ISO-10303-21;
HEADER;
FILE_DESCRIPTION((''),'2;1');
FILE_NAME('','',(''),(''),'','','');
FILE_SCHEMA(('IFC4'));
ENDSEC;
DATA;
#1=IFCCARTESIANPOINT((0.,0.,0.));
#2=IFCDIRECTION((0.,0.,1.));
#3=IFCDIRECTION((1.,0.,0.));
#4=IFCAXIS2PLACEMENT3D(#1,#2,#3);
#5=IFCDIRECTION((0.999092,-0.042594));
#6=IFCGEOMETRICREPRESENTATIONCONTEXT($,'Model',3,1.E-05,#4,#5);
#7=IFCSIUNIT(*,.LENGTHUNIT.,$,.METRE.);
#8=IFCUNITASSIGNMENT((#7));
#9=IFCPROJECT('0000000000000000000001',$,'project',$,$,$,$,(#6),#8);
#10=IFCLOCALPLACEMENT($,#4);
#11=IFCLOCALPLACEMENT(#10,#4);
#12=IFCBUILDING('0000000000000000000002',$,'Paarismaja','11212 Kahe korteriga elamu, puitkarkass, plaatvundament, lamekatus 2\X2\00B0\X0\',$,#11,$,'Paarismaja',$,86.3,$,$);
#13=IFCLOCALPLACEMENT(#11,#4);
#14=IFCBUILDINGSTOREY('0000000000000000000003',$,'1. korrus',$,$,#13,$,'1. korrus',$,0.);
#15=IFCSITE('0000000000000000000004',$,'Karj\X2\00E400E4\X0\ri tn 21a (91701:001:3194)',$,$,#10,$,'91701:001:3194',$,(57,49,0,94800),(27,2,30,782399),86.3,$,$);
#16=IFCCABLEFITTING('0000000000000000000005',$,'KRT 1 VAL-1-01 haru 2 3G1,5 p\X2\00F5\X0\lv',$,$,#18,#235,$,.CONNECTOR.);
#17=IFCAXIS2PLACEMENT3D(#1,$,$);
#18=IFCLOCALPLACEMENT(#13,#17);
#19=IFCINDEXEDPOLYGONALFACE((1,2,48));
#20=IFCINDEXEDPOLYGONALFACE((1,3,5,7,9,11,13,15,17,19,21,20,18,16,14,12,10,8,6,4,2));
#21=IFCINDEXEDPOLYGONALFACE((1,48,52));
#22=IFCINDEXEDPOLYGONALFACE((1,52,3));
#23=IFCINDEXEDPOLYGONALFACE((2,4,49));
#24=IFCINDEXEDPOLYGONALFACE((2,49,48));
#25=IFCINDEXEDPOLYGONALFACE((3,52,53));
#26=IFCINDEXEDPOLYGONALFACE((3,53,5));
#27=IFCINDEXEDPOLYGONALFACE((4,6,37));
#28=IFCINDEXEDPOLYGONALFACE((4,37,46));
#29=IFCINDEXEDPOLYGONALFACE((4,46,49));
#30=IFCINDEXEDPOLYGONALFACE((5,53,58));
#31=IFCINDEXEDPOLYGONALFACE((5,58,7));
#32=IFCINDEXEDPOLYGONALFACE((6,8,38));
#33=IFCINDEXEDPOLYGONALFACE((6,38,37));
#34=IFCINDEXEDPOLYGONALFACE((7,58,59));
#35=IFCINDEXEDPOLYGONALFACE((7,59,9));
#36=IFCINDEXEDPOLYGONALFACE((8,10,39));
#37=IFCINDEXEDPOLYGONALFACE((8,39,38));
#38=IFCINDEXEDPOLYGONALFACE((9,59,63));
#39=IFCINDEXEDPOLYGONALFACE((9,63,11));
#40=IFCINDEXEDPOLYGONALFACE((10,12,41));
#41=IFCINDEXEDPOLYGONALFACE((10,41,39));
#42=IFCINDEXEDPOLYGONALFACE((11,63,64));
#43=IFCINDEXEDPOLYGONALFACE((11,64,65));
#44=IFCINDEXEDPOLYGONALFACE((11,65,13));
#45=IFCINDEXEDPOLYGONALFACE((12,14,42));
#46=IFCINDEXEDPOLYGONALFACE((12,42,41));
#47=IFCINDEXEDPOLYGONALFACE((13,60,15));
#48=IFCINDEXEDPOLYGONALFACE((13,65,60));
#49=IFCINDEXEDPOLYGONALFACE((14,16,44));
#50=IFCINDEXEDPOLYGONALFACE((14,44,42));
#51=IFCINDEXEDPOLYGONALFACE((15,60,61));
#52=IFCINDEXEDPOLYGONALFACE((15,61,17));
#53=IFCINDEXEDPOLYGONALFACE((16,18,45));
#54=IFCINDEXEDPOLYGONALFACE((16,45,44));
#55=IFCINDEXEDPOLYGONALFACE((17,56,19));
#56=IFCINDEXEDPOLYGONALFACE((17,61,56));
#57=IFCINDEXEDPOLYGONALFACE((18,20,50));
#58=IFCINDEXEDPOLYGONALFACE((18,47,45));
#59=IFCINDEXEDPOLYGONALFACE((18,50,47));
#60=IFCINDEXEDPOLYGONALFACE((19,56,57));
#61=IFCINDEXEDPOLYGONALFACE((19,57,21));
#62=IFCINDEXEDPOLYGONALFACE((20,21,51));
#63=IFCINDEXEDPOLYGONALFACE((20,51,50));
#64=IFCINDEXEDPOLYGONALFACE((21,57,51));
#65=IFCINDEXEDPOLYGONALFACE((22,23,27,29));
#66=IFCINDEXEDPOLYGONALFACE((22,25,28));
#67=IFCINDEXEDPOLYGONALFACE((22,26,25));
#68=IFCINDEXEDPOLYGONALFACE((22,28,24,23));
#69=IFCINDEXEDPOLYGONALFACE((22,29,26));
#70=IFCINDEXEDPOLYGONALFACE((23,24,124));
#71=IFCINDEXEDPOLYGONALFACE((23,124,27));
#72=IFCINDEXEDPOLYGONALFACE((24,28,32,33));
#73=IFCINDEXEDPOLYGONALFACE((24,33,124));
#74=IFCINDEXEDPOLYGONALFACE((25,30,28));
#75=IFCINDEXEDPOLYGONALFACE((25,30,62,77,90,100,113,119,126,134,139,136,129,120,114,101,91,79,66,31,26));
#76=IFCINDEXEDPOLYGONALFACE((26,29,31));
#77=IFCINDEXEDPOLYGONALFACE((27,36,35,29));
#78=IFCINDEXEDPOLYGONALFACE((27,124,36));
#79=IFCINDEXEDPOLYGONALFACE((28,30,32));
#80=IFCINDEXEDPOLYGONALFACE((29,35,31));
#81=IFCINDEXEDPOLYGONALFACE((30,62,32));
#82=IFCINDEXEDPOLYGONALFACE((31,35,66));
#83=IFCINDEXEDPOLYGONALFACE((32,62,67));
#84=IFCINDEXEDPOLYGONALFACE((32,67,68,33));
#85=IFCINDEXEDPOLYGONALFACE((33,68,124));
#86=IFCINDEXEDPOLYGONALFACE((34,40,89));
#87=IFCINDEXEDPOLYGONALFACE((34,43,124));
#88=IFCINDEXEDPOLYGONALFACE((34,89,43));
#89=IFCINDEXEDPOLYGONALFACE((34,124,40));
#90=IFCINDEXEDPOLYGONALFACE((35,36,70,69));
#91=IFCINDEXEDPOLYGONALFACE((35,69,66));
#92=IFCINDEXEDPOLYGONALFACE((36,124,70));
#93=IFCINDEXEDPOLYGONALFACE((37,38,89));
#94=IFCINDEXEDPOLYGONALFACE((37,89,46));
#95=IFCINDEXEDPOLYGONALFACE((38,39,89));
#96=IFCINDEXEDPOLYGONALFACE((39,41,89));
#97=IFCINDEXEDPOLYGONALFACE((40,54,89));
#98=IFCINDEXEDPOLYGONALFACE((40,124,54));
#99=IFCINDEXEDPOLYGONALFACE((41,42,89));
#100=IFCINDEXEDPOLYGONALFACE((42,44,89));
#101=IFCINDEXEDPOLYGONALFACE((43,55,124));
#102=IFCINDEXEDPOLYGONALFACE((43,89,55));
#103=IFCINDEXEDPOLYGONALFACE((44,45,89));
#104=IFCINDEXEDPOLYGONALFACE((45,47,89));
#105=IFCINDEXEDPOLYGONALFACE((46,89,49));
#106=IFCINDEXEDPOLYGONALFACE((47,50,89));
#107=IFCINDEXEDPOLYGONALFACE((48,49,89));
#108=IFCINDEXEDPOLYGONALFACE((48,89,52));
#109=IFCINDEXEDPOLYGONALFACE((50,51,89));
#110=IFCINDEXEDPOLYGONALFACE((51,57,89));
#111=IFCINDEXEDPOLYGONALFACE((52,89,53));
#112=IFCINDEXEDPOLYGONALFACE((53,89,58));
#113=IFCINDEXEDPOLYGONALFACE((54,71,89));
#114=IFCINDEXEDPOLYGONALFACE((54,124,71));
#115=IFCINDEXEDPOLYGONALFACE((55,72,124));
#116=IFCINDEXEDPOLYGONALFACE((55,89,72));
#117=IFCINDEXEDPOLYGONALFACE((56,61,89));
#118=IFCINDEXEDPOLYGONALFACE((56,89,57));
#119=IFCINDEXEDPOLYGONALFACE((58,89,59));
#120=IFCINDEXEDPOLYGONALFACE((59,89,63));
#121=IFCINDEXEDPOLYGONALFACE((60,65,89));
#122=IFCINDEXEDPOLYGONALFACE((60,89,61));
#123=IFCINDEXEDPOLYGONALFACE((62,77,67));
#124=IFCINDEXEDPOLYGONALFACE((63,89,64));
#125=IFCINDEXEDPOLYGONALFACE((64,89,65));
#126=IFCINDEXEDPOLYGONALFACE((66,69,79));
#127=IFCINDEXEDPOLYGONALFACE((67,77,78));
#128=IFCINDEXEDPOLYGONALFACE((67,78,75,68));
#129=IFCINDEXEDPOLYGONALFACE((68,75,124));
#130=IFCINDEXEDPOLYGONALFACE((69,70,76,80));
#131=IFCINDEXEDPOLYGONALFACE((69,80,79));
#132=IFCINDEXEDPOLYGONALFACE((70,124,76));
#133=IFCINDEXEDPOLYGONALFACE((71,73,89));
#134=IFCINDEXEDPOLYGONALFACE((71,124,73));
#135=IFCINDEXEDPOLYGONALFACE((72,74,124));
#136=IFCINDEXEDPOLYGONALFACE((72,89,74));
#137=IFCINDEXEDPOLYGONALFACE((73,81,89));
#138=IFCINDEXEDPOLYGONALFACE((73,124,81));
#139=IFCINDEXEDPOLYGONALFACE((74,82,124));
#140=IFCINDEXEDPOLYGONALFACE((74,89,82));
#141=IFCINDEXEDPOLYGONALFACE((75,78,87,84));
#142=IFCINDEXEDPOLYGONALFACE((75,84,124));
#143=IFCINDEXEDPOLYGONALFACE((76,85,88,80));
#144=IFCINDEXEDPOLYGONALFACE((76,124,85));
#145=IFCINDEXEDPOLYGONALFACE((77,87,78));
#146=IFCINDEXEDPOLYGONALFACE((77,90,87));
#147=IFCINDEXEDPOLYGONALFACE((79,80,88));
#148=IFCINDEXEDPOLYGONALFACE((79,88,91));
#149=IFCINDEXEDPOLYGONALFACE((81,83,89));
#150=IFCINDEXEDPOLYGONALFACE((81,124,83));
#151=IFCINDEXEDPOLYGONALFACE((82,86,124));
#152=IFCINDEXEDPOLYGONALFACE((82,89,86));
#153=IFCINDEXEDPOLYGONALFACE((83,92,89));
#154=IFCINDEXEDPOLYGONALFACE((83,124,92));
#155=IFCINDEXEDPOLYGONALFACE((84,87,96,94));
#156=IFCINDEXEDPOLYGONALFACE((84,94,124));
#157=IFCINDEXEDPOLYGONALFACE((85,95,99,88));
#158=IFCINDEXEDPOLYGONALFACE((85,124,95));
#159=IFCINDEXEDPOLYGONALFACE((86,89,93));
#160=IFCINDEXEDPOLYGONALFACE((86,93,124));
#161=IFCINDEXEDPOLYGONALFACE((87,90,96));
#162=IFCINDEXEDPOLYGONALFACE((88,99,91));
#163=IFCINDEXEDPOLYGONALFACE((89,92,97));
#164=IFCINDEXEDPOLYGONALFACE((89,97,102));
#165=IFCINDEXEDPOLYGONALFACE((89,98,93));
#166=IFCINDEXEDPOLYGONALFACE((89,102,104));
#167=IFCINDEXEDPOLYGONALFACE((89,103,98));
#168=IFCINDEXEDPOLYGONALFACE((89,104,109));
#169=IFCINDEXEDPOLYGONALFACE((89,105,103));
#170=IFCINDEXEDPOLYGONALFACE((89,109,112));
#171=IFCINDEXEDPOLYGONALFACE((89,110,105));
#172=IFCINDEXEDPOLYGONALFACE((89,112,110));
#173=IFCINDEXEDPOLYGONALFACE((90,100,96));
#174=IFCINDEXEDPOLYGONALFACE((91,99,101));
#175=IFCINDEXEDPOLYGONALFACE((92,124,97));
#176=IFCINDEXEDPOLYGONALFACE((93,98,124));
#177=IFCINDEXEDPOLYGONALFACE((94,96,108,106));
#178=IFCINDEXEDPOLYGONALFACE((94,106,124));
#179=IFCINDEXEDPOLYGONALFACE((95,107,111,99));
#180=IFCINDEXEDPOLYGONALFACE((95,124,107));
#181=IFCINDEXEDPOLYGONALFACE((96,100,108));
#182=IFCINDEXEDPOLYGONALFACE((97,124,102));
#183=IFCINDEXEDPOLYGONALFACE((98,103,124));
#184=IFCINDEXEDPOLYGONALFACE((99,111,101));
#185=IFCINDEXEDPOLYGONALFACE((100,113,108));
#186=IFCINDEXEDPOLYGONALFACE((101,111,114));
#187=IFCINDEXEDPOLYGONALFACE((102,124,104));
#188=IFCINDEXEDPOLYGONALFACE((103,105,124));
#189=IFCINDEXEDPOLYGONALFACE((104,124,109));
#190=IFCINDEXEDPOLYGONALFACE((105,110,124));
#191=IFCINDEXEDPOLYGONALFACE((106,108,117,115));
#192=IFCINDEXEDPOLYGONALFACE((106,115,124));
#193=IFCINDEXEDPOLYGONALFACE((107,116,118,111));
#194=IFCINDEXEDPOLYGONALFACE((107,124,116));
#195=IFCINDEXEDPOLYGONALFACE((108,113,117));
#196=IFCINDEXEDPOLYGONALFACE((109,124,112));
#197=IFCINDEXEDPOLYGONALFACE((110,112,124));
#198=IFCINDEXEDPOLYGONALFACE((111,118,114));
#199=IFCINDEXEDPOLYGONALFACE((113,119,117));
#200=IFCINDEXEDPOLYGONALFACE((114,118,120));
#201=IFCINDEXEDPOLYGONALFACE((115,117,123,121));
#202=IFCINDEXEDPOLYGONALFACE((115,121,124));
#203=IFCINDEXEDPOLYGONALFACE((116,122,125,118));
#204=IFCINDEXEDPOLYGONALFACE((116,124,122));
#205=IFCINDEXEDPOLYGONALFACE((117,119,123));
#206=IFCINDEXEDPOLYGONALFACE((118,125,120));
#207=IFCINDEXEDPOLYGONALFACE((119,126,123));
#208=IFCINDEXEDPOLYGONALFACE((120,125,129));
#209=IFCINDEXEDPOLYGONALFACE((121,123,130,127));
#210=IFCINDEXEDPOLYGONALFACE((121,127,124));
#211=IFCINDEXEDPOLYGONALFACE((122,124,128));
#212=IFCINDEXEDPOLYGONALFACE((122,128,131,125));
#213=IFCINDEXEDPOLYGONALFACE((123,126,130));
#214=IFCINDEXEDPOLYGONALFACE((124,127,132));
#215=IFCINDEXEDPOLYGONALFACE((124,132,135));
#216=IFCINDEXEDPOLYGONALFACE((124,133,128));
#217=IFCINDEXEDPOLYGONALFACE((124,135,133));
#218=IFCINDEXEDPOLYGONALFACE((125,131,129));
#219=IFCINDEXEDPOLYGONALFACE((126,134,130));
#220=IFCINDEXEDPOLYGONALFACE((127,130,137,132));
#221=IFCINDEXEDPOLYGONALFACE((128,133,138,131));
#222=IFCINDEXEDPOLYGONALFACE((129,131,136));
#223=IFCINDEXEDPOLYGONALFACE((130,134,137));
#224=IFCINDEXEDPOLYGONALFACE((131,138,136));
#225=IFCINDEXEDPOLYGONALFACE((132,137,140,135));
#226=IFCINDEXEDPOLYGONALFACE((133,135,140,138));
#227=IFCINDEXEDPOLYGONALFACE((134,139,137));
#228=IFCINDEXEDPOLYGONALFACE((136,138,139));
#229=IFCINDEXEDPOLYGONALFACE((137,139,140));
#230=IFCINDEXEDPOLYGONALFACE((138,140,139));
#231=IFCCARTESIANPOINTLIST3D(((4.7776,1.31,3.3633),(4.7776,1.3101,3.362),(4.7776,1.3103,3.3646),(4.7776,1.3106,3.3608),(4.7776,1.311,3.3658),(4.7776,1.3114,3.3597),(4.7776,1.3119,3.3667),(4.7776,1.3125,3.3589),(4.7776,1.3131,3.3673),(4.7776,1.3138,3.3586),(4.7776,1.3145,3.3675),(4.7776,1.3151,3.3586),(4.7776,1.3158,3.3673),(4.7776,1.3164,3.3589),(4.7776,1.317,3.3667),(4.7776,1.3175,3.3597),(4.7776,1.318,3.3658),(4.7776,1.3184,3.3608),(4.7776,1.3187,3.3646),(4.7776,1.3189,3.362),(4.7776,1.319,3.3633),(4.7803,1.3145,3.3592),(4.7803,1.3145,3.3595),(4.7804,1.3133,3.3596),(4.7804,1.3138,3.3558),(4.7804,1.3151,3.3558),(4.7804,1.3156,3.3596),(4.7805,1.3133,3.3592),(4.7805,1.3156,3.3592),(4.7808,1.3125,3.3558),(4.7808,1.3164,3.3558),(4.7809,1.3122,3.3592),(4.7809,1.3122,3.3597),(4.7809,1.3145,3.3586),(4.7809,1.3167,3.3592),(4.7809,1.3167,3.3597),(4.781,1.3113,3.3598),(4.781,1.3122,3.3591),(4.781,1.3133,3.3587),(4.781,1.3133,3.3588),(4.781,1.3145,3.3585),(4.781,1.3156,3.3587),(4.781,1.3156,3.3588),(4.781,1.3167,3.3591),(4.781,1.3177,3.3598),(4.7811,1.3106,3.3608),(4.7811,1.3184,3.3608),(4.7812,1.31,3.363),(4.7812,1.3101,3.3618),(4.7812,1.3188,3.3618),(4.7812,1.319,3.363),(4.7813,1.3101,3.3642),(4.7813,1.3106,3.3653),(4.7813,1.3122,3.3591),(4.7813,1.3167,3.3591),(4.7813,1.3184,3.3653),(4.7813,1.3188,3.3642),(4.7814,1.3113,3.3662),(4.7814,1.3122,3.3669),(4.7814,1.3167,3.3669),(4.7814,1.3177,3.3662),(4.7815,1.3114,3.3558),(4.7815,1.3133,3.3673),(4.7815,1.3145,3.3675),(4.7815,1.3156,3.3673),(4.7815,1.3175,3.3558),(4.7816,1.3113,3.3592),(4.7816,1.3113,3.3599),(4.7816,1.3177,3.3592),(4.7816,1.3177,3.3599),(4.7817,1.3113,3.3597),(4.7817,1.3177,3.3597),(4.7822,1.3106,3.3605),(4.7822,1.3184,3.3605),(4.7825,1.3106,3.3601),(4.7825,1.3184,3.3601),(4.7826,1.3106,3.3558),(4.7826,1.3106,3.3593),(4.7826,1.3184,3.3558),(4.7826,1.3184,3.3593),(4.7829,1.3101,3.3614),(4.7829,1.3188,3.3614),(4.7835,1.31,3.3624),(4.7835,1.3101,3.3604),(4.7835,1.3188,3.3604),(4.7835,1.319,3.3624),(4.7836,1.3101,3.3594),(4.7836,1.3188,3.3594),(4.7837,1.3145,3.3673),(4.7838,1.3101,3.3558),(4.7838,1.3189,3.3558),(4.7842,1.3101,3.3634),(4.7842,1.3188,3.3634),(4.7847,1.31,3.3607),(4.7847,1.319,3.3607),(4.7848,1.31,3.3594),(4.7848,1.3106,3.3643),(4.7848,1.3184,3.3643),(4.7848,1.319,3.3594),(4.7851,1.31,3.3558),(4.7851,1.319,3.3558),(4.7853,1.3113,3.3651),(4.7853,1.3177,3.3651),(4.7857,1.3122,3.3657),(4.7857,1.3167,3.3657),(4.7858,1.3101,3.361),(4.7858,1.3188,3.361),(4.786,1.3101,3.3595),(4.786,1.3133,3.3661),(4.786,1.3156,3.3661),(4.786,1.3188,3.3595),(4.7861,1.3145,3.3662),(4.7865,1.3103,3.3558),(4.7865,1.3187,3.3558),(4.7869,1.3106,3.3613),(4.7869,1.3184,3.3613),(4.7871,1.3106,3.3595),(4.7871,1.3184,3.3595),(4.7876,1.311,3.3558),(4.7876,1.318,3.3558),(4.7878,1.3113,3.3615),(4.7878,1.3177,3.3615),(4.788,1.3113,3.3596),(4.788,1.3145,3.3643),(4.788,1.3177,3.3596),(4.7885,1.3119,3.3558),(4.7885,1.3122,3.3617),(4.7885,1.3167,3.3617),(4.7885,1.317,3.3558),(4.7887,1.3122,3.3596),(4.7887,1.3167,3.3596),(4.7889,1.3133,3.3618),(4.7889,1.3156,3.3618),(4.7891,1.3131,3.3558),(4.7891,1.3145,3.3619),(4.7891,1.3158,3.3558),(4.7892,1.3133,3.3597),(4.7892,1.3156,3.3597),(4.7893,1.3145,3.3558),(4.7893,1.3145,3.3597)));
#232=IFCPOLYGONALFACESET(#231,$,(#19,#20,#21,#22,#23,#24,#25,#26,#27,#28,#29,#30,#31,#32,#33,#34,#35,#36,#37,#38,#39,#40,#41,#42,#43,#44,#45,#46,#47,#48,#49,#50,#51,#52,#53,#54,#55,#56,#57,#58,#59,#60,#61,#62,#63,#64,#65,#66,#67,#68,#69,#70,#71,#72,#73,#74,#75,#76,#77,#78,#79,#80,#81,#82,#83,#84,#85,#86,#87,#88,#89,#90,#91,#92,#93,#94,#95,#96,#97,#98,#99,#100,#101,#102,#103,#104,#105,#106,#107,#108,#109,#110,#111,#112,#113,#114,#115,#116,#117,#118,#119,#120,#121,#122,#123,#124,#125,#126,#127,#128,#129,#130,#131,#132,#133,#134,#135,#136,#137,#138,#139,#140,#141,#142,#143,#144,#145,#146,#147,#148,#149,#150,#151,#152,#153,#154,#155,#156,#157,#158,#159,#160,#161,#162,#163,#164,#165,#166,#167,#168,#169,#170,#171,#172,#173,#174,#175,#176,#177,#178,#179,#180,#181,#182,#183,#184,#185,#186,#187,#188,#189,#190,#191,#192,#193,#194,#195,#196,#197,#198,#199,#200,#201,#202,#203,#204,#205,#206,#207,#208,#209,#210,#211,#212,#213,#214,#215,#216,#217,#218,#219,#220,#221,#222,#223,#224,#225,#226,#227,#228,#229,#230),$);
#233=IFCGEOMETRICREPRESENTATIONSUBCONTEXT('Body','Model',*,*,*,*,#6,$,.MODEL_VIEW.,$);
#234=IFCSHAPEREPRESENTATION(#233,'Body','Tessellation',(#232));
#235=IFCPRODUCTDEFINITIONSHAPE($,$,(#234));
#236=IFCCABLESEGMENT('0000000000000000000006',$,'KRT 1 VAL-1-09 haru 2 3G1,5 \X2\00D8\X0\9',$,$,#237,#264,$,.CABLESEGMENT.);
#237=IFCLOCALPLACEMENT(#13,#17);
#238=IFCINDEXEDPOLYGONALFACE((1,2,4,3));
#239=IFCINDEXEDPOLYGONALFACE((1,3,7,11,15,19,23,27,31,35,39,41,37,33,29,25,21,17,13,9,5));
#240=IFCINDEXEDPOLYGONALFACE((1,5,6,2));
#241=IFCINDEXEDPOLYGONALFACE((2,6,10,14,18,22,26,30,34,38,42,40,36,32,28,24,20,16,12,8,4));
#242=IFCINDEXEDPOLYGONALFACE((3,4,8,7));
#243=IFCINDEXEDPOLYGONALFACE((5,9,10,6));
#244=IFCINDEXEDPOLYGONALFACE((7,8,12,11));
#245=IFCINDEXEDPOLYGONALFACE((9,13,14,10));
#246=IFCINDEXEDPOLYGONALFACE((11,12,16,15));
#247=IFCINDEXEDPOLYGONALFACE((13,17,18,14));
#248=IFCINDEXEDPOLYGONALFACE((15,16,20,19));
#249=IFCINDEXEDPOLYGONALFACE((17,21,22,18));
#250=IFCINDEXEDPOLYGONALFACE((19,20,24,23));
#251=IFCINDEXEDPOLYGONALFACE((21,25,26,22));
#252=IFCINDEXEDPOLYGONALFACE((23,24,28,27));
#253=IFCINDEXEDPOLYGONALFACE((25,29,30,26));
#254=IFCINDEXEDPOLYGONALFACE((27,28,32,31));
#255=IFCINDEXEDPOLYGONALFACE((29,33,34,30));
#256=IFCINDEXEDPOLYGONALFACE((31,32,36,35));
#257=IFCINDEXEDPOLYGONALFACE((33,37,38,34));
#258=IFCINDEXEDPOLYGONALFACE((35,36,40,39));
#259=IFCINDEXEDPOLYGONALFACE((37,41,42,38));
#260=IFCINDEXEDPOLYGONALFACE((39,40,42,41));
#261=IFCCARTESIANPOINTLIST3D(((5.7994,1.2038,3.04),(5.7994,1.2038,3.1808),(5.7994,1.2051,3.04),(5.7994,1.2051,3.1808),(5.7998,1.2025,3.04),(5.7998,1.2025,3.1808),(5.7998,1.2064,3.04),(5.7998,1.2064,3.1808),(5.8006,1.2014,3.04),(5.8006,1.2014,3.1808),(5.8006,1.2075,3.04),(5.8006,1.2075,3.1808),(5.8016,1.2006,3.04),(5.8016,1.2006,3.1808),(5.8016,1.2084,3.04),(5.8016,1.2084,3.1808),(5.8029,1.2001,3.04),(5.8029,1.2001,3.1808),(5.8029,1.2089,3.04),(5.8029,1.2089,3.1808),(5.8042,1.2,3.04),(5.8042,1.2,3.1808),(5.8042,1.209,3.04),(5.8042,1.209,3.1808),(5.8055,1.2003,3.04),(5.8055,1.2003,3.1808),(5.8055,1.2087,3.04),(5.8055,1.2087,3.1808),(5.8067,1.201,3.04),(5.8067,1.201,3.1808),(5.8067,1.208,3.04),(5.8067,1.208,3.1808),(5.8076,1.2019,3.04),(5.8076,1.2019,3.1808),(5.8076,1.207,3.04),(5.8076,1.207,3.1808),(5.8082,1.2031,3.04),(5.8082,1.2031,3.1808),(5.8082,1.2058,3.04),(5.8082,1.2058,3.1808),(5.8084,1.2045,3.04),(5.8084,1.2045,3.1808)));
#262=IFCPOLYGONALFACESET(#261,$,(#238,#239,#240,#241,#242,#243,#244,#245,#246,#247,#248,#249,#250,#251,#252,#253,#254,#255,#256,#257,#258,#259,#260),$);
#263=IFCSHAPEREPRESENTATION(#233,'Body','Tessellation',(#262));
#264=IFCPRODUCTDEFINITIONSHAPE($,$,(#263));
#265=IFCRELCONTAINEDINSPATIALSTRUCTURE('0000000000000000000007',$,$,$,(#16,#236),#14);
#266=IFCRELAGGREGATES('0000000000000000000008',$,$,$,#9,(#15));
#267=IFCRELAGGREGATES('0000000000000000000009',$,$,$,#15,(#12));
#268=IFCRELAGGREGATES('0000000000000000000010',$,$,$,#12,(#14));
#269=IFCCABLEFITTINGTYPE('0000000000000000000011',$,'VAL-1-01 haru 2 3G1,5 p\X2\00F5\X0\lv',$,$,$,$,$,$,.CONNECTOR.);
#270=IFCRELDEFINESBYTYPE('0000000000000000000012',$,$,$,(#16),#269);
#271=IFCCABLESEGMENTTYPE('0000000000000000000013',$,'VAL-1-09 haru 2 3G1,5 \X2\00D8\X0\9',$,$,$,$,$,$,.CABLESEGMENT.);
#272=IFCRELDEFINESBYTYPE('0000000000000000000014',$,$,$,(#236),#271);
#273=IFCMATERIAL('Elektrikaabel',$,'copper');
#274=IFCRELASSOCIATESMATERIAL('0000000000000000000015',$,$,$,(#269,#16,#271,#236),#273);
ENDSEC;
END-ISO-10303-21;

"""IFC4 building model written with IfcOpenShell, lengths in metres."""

from ifc_helpers import new_model, entity, si_unit, direction, frame, origin_with_axes, place, context, subcontext, project, spatial, circle, extrude, material, type_object, element, save


model = new_model("IFC4")

# Units and contexts
model_context = context("Model", 3, precision=1e-05, world=origin_with_axes(), true_north=direction((0.999092, -0.042594)))
body_context = subcontext(model_context, "Body", "Model", "MODEL_VIEW")
ifc_project = project(units=[si_unit("LENGTHUNIT", "METRE")], contexts=[model_context])

# Site, building, storey
site_placement = place(None, origin_with_axes())
site = spatial("IfcSite", under=ifc_project, at=site_placement, Name="Karjääri tn 21a (91701:001:3194)", LongName="91701:001:3194", RefLatitude=(57, 49, 0, 94800), RefLongitude=(27, 2, 30, 782399), RefElevation=86.3)
building_placement = place(site_placement, origin_with_axes())
building = spatial("IfcBuilding", under=site, at=building_placement, Name="Paarismaja", Description="11212 Kahe korteriga elamu, puitkarkass, plaatvundament, lamekatus 2°", LongName="Paarismaja", ElevationOfRefHeight=86.3)
storey_placement = place(building_placement, origin_with_axes())
storey = spatial("IfcBuildingStorey", under=building, at=storey_placement, Name="1. korrus", LongName="1. korrus", Elevation=0.0)

# Cable fitting
ifc_material_1 = material(Name="Elektrikaabel", Category="copper")
cable_fitting_type_1 = type_object("IfcCableFittingType", Name="VAL-1-01 haru 2 3G1,5 põlv", PredefinedType="CONNECTOR", material=ifc_material_1)
cable_fitting_1_placement = place(storey_placement, frame((4.7848, 1.3145, 3.363), z_axis=(0.0, 0.0, 1.0), x_axis=(1.0, 0.0, 0.0)))
element("IfcCableFitting", 1, at=cable_fitting_1_placement, inside=storey, type_object=cable_fitting_type_1, material=ifc_material_1, Name="KRT 1 VAL-1-01 haru 2 3G1,5 põlv", PredefinedType="CONNECTOR", context=body_context, shape_type="AdvancedSweptSolid", body=[
    entity("IfcSweptDiskSolid", entity("IfcIndexedPolyCurve", entity("IfcCartesianPointList3D", [[0.0, 0.0, -0.0072], [0.0, 0.0, -0.0036], [-0.0001, 0.0, -0.0023], [-0.0006, 0.0, -0.0013], [-0.0013, 0.0, -0.0006], [-0.0023, 0.0, -0.0001], [-0.0036, 0.0, 0.0], [-0.0072, 0.0, 0.0]]), None, False), 0.0045),
])

# Cable segment
cable_segment_type_1 = type_object("IfcCableSegmentType", Name="VAL-1-09 haru 2 3G1,5 Ø9", PredefinedType="CABLESEGMENT", material=ifc_material_1)
cable_segment_1_placement = place(storey_placement, frame((5.8039, 1.2045, 3.1808), z_axis=(0.0, 0.0, -1.0), x_axis=(1.0, 0.0, 0.0)))
element("IfcCableSegment", 2, at=cable_segment_1_placement, inside=storey, type_object=cable_segment_type_1, material=ifc_material_1, Name="KRT 1 VAL-1-09 haru 2 3G1,5 Ø9", PredefinedType="CABLESEGMENT", context=body_context, shape_type="SweptSolid", body=[
    extrude(circle(Radius=0.0045), origin_with_axes(), (0.0, 0.0, 1.0), 0.1408),
])

save(model, "model.ifc")
